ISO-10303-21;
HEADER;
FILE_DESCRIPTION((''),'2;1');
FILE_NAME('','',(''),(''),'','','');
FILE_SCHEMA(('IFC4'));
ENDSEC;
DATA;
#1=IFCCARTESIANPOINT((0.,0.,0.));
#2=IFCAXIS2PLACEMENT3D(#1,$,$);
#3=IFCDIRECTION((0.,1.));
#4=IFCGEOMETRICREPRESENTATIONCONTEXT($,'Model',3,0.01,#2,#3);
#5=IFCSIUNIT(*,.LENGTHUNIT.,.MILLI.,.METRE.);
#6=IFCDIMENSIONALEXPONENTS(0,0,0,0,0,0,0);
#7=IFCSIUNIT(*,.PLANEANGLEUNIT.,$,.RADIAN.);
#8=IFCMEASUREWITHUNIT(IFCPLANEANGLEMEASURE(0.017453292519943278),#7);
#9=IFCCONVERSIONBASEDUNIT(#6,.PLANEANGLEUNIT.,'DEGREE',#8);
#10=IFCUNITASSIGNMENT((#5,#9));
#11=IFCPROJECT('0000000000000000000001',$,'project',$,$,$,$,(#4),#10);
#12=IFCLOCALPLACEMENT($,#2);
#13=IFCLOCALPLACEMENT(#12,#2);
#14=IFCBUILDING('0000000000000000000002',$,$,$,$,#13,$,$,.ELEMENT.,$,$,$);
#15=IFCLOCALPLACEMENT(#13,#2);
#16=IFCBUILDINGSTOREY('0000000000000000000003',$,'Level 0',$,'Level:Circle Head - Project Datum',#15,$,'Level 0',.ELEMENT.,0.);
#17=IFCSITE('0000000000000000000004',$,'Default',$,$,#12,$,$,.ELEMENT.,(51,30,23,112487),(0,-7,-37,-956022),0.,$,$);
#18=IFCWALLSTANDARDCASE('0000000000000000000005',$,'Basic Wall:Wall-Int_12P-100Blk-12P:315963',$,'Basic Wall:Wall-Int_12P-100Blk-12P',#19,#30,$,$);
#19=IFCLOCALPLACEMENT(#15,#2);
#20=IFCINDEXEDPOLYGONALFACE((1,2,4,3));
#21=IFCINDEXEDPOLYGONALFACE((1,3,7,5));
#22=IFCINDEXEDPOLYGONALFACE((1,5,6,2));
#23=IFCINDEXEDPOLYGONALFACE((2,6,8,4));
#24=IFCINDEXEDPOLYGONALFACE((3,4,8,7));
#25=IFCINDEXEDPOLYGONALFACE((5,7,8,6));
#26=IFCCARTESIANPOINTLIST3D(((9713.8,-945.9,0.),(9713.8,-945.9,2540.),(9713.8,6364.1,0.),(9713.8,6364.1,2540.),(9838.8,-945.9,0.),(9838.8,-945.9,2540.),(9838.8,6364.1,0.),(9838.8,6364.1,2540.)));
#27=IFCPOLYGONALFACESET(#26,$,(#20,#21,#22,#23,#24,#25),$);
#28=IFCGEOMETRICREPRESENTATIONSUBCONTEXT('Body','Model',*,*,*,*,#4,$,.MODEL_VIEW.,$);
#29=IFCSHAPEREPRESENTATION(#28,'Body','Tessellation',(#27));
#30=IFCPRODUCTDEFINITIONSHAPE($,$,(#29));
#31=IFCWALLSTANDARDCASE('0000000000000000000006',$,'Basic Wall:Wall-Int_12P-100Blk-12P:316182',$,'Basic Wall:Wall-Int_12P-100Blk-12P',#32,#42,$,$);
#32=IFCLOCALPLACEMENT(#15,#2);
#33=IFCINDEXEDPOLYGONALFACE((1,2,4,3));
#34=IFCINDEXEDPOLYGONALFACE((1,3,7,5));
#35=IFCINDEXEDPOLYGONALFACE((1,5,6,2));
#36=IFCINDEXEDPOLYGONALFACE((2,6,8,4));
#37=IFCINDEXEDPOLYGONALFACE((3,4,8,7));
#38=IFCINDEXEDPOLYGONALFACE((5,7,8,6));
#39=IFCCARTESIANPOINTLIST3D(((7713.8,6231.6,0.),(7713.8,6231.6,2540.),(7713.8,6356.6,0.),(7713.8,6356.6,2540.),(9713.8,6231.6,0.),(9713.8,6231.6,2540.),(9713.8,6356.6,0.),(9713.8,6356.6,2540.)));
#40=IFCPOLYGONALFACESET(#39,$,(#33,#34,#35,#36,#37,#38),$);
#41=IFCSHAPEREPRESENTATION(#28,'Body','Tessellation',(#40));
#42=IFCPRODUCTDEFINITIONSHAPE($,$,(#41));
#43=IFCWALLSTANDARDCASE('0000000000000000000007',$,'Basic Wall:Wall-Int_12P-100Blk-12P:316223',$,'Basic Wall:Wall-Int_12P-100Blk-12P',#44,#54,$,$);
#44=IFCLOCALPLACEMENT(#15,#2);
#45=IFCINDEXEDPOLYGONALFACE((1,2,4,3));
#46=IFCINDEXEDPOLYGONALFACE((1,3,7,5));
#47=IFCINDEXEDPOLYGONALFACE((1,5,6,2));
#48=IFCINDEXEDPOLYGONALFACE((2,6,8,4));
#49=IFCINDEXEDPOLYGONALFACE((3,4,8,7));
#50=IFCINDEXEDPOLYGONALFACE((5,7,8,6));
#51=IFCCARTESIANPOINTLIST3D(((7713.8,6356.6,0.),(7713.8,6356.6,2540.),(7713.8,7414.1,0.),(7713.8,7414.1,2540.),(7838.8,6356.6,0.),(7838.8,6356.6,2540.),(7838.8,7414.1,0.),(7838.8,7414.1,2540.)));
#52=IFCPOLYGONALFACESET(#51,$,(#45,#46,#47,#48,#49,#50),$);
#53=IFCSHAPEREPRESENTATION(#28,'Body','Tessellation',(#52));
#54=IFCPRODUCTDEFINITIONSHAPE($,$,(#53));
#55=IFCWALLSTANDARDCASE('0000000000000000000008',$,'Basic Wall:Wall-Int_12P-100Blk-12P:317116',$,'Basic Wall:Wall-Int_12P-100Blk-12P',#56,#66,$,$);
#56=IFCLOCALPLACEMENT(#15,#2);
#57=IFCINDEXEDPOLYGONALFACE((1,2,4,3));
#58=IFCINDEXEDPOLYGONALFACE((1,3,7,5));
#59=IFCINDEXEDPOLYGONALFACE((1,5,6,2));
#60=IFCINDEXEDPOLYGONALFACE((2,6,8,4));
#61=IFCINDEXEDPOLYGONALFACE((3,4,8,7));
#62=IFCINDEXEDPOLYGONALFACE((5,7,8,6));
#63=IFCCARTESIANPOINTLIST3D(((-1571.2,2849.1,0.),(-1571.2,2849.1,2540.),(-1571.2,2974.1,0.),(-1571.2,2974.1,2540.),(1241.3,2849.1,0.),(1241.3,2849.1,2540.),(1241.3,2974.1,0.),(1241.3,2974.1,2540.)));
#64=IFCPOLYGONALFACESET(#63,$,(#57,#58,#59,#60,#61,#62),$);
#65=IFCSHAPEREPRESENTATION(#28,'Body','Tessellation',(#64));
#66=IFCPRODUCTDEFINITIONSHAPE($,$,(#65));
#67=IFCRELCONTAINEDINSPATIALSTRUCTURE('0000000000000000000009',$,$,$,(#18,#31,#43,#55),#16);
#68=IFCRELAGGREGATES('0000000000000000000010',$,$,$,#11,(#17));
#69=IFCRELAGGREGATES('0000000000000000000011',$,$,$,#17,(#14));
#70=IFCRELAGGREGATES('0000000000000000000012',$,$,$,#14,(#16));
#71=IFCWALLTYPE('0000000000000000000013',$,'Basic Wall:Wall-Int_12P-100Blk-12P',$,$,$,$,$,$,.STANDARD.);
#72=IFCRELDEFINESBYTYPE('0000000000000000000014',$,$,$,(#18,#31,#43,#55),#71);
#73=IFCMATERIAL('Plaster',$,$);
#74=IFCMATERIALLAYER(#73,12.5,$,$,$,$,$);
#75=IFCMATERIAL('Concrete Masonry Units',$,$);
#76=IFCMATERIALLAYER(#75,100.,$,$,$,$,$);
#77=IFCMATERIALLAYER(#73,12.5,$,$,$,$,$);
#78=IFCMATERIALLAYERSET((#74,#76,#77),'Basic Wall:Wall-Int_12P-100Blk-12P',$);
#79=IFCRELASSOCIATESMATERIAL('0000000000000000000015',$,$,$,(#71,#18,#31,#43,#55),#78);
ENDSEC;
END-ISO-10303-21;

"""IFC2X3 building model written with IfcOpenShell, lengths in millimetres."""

from ifc_helpers import new_model, entity, si_unit, converted_unit, direction, frame, frame_2d, origin, place, context, subcontext, project, spatial, rectangle, extrude, material, layer, layer_set, layer_usage, type_object, element, save


model = new_model("IFC2X3")

# Units and contexts
model_context = context("Model", 3, precision=0.01, world=origin(), true_north=direction((0.0, 1.0)))
body_context = subcontext(model_context, "Body", "Model", "MODEL_VIEW")
ifc_project = project(units=[si_unit("LENGTHUNIT", "METRE", prefix="MILLI"), converted_unit("PLANEANGLEUNIT", "DEGREE", entity("IfcPlaneAngleMeasure", 0.017453292519943278), si_unit("PLANEANGLEUNIT", "RADIAN"), dimensions=[0, 0, 0, 0, 0, 0, 0])], contexts=[model_context])

# Site, building, storey
site_placement = place(None, origin())
site = spatial("IfcSite", under=ifc_project, at=site_placement, Name="Default", CompositionType="ELEMENT", RefLatitude=(51, 30, 23, 112487), RefLongitude=(0, -7, -37, -956022), RefElevation=0.0)
building_placement = place(site_placement, origin())
building = spatial("IfcBuilding", under=site, at=building_placement, CompositionType="ELEMENT")
storey_placement = place(building_placement, origin())
storey = spatial("IfcBuildingStorey", under=building, at=storey_placement, Name="Level 0", ObjectType="Level:Circle Head - Project Datum", LongName="Level 0", CompositionType="ELEMENT", Elevation=0.0)

# Shared definitions
ifc_material_1 = material(Name="Plaster")

# Walls
ifc_layer_1 = layer(ifc_material_1, 12.5)
ifc_material_2 = material(Name="Concrete Masonry Units")
ifc_layer_2 = layer(ifc_material_2, 100.0)
ifc_layer_3 = layer(ifc_material_1, 12.5)
ifc_layer_set_1 = layer_set([ifc_layer_1, ifc_layer_2, ifc_layer_3], Name="Basic Wall:Wall-Int_12P-100Blk-12P")
ifc_layer_usage_1 = layer_usage(ifc_layer_set_1, "AXIS2", "NEGATIVE", 62.5)
wall_type_1 = type_object("IfcWallType", Name="Basic Wall:Wall-Int_12P-100Blk-12P", PredefinedType="STANDARD", material=ifc_layer_set_1)
wall_1_placement = place(storey_placement, frame((9776.3, -945.9, 0.0), z_axis=(0.0, 0.0, 1.0), x_axis=(0.0, 1.0, 0.0)))
element("IfcWallStandardCase", 1, at=wall_1_placement, inside=storey, type_object=wall_type_1, material=ifc_layer_usage_1, Name="Basic Wall:Wall-Int_12P-100Blk-12P:315963", ObjectType="Basic Wall:Wall-Int_12P-100Blk-12P", context=body_context, shape_type="SweptSolid", body=[
    extrude(rectangle(XDim=7310.0, YDim=125.0, at=frame_2d((3655.0, 0.0), x_axis=(-1.0, 0.0))), origin(), (0.0, 0.0, 1.0), 2540.0),
])
wall_2_placement = place(storey_placement, frame((9713.8, 6294.1, 0.0), z_axis=(0.0, 0.0, 1.0), x_axis=(-1.0, 0.0, 0.0)))
element("IfcWallStandardCase", 2, at=wall_2_placement, inside=storey, type_object=wall_type_1, material=ifc_layer_usage_1, Name="Basic Wall:Wall-Int_12P-100Blk-12P:316182", ObjectType="Basic Wall:Wall-Int_12P-100Blk-12P", context=body_context, shape_type="SweptSolid", body=[
    extrude(rectangle(XDim=2000.0, YDim=125.0, at=frame_2d((1000.0, 0.0), x_axis=(-1.0, 0.0))), origin(), (0.0, 0.0, 1.0), 2540.0),
])
wall_3_placement = place(storey_placement, frame((7776.3, 6356.6, 0.0), z_axis=(0.0, 0.0, 1.0), x_axis=(0.0, 1.0, 0.0)))
element("IfcWallStandardCase", 3, at=wall_3_placement, inside=storey, type_object=wall_type_1, material=ifc_layer_usage_1, Name="Basic Wall:Wall-Int_12P-100Blk-12P:316223", ObjectType="Basic Wall:Wall-Int_12P-100Blk-12P", context=body_context, shape_type="SweptSolid", body=[
    extrude(rectangle(XDim=1057.5, YDim=125.0, at=frame_2d((528.8, 0.0), x_axis=(-1.0, 0.0))), origin(), (0.0, 0.0, 1.0), 2540.0),
])
wall_4_placement = place(storey_placement, frame((1241.3, 2911.6, 0.0), z_axis=(0.0, 0.0, 1.0), x_axis=(-1.0, 0.0, 0.0)))
element("IfcWallStandardCase", 4, at=wall_4_placement, inside=storey, type_object=wall_type_1, material=ifc_layer_usage_1, Name="Basic Wall:Wall-Int_12P-100Blk-12P:317116", ObjectType="Basic Wall:Wall-Int_12P-100Blk-12P", context=body_context, shape_type="SweptSolid", body=[
    extrude(rectangle(XDim=2812.5, YDim=125.0, at=frame_2d((1406.3, 0.0), x_axis=(-1.0, 0.0))), origin(), (0.0, 0.0, 1.0), 2540.0),
])

save(model, "model.ifc")
